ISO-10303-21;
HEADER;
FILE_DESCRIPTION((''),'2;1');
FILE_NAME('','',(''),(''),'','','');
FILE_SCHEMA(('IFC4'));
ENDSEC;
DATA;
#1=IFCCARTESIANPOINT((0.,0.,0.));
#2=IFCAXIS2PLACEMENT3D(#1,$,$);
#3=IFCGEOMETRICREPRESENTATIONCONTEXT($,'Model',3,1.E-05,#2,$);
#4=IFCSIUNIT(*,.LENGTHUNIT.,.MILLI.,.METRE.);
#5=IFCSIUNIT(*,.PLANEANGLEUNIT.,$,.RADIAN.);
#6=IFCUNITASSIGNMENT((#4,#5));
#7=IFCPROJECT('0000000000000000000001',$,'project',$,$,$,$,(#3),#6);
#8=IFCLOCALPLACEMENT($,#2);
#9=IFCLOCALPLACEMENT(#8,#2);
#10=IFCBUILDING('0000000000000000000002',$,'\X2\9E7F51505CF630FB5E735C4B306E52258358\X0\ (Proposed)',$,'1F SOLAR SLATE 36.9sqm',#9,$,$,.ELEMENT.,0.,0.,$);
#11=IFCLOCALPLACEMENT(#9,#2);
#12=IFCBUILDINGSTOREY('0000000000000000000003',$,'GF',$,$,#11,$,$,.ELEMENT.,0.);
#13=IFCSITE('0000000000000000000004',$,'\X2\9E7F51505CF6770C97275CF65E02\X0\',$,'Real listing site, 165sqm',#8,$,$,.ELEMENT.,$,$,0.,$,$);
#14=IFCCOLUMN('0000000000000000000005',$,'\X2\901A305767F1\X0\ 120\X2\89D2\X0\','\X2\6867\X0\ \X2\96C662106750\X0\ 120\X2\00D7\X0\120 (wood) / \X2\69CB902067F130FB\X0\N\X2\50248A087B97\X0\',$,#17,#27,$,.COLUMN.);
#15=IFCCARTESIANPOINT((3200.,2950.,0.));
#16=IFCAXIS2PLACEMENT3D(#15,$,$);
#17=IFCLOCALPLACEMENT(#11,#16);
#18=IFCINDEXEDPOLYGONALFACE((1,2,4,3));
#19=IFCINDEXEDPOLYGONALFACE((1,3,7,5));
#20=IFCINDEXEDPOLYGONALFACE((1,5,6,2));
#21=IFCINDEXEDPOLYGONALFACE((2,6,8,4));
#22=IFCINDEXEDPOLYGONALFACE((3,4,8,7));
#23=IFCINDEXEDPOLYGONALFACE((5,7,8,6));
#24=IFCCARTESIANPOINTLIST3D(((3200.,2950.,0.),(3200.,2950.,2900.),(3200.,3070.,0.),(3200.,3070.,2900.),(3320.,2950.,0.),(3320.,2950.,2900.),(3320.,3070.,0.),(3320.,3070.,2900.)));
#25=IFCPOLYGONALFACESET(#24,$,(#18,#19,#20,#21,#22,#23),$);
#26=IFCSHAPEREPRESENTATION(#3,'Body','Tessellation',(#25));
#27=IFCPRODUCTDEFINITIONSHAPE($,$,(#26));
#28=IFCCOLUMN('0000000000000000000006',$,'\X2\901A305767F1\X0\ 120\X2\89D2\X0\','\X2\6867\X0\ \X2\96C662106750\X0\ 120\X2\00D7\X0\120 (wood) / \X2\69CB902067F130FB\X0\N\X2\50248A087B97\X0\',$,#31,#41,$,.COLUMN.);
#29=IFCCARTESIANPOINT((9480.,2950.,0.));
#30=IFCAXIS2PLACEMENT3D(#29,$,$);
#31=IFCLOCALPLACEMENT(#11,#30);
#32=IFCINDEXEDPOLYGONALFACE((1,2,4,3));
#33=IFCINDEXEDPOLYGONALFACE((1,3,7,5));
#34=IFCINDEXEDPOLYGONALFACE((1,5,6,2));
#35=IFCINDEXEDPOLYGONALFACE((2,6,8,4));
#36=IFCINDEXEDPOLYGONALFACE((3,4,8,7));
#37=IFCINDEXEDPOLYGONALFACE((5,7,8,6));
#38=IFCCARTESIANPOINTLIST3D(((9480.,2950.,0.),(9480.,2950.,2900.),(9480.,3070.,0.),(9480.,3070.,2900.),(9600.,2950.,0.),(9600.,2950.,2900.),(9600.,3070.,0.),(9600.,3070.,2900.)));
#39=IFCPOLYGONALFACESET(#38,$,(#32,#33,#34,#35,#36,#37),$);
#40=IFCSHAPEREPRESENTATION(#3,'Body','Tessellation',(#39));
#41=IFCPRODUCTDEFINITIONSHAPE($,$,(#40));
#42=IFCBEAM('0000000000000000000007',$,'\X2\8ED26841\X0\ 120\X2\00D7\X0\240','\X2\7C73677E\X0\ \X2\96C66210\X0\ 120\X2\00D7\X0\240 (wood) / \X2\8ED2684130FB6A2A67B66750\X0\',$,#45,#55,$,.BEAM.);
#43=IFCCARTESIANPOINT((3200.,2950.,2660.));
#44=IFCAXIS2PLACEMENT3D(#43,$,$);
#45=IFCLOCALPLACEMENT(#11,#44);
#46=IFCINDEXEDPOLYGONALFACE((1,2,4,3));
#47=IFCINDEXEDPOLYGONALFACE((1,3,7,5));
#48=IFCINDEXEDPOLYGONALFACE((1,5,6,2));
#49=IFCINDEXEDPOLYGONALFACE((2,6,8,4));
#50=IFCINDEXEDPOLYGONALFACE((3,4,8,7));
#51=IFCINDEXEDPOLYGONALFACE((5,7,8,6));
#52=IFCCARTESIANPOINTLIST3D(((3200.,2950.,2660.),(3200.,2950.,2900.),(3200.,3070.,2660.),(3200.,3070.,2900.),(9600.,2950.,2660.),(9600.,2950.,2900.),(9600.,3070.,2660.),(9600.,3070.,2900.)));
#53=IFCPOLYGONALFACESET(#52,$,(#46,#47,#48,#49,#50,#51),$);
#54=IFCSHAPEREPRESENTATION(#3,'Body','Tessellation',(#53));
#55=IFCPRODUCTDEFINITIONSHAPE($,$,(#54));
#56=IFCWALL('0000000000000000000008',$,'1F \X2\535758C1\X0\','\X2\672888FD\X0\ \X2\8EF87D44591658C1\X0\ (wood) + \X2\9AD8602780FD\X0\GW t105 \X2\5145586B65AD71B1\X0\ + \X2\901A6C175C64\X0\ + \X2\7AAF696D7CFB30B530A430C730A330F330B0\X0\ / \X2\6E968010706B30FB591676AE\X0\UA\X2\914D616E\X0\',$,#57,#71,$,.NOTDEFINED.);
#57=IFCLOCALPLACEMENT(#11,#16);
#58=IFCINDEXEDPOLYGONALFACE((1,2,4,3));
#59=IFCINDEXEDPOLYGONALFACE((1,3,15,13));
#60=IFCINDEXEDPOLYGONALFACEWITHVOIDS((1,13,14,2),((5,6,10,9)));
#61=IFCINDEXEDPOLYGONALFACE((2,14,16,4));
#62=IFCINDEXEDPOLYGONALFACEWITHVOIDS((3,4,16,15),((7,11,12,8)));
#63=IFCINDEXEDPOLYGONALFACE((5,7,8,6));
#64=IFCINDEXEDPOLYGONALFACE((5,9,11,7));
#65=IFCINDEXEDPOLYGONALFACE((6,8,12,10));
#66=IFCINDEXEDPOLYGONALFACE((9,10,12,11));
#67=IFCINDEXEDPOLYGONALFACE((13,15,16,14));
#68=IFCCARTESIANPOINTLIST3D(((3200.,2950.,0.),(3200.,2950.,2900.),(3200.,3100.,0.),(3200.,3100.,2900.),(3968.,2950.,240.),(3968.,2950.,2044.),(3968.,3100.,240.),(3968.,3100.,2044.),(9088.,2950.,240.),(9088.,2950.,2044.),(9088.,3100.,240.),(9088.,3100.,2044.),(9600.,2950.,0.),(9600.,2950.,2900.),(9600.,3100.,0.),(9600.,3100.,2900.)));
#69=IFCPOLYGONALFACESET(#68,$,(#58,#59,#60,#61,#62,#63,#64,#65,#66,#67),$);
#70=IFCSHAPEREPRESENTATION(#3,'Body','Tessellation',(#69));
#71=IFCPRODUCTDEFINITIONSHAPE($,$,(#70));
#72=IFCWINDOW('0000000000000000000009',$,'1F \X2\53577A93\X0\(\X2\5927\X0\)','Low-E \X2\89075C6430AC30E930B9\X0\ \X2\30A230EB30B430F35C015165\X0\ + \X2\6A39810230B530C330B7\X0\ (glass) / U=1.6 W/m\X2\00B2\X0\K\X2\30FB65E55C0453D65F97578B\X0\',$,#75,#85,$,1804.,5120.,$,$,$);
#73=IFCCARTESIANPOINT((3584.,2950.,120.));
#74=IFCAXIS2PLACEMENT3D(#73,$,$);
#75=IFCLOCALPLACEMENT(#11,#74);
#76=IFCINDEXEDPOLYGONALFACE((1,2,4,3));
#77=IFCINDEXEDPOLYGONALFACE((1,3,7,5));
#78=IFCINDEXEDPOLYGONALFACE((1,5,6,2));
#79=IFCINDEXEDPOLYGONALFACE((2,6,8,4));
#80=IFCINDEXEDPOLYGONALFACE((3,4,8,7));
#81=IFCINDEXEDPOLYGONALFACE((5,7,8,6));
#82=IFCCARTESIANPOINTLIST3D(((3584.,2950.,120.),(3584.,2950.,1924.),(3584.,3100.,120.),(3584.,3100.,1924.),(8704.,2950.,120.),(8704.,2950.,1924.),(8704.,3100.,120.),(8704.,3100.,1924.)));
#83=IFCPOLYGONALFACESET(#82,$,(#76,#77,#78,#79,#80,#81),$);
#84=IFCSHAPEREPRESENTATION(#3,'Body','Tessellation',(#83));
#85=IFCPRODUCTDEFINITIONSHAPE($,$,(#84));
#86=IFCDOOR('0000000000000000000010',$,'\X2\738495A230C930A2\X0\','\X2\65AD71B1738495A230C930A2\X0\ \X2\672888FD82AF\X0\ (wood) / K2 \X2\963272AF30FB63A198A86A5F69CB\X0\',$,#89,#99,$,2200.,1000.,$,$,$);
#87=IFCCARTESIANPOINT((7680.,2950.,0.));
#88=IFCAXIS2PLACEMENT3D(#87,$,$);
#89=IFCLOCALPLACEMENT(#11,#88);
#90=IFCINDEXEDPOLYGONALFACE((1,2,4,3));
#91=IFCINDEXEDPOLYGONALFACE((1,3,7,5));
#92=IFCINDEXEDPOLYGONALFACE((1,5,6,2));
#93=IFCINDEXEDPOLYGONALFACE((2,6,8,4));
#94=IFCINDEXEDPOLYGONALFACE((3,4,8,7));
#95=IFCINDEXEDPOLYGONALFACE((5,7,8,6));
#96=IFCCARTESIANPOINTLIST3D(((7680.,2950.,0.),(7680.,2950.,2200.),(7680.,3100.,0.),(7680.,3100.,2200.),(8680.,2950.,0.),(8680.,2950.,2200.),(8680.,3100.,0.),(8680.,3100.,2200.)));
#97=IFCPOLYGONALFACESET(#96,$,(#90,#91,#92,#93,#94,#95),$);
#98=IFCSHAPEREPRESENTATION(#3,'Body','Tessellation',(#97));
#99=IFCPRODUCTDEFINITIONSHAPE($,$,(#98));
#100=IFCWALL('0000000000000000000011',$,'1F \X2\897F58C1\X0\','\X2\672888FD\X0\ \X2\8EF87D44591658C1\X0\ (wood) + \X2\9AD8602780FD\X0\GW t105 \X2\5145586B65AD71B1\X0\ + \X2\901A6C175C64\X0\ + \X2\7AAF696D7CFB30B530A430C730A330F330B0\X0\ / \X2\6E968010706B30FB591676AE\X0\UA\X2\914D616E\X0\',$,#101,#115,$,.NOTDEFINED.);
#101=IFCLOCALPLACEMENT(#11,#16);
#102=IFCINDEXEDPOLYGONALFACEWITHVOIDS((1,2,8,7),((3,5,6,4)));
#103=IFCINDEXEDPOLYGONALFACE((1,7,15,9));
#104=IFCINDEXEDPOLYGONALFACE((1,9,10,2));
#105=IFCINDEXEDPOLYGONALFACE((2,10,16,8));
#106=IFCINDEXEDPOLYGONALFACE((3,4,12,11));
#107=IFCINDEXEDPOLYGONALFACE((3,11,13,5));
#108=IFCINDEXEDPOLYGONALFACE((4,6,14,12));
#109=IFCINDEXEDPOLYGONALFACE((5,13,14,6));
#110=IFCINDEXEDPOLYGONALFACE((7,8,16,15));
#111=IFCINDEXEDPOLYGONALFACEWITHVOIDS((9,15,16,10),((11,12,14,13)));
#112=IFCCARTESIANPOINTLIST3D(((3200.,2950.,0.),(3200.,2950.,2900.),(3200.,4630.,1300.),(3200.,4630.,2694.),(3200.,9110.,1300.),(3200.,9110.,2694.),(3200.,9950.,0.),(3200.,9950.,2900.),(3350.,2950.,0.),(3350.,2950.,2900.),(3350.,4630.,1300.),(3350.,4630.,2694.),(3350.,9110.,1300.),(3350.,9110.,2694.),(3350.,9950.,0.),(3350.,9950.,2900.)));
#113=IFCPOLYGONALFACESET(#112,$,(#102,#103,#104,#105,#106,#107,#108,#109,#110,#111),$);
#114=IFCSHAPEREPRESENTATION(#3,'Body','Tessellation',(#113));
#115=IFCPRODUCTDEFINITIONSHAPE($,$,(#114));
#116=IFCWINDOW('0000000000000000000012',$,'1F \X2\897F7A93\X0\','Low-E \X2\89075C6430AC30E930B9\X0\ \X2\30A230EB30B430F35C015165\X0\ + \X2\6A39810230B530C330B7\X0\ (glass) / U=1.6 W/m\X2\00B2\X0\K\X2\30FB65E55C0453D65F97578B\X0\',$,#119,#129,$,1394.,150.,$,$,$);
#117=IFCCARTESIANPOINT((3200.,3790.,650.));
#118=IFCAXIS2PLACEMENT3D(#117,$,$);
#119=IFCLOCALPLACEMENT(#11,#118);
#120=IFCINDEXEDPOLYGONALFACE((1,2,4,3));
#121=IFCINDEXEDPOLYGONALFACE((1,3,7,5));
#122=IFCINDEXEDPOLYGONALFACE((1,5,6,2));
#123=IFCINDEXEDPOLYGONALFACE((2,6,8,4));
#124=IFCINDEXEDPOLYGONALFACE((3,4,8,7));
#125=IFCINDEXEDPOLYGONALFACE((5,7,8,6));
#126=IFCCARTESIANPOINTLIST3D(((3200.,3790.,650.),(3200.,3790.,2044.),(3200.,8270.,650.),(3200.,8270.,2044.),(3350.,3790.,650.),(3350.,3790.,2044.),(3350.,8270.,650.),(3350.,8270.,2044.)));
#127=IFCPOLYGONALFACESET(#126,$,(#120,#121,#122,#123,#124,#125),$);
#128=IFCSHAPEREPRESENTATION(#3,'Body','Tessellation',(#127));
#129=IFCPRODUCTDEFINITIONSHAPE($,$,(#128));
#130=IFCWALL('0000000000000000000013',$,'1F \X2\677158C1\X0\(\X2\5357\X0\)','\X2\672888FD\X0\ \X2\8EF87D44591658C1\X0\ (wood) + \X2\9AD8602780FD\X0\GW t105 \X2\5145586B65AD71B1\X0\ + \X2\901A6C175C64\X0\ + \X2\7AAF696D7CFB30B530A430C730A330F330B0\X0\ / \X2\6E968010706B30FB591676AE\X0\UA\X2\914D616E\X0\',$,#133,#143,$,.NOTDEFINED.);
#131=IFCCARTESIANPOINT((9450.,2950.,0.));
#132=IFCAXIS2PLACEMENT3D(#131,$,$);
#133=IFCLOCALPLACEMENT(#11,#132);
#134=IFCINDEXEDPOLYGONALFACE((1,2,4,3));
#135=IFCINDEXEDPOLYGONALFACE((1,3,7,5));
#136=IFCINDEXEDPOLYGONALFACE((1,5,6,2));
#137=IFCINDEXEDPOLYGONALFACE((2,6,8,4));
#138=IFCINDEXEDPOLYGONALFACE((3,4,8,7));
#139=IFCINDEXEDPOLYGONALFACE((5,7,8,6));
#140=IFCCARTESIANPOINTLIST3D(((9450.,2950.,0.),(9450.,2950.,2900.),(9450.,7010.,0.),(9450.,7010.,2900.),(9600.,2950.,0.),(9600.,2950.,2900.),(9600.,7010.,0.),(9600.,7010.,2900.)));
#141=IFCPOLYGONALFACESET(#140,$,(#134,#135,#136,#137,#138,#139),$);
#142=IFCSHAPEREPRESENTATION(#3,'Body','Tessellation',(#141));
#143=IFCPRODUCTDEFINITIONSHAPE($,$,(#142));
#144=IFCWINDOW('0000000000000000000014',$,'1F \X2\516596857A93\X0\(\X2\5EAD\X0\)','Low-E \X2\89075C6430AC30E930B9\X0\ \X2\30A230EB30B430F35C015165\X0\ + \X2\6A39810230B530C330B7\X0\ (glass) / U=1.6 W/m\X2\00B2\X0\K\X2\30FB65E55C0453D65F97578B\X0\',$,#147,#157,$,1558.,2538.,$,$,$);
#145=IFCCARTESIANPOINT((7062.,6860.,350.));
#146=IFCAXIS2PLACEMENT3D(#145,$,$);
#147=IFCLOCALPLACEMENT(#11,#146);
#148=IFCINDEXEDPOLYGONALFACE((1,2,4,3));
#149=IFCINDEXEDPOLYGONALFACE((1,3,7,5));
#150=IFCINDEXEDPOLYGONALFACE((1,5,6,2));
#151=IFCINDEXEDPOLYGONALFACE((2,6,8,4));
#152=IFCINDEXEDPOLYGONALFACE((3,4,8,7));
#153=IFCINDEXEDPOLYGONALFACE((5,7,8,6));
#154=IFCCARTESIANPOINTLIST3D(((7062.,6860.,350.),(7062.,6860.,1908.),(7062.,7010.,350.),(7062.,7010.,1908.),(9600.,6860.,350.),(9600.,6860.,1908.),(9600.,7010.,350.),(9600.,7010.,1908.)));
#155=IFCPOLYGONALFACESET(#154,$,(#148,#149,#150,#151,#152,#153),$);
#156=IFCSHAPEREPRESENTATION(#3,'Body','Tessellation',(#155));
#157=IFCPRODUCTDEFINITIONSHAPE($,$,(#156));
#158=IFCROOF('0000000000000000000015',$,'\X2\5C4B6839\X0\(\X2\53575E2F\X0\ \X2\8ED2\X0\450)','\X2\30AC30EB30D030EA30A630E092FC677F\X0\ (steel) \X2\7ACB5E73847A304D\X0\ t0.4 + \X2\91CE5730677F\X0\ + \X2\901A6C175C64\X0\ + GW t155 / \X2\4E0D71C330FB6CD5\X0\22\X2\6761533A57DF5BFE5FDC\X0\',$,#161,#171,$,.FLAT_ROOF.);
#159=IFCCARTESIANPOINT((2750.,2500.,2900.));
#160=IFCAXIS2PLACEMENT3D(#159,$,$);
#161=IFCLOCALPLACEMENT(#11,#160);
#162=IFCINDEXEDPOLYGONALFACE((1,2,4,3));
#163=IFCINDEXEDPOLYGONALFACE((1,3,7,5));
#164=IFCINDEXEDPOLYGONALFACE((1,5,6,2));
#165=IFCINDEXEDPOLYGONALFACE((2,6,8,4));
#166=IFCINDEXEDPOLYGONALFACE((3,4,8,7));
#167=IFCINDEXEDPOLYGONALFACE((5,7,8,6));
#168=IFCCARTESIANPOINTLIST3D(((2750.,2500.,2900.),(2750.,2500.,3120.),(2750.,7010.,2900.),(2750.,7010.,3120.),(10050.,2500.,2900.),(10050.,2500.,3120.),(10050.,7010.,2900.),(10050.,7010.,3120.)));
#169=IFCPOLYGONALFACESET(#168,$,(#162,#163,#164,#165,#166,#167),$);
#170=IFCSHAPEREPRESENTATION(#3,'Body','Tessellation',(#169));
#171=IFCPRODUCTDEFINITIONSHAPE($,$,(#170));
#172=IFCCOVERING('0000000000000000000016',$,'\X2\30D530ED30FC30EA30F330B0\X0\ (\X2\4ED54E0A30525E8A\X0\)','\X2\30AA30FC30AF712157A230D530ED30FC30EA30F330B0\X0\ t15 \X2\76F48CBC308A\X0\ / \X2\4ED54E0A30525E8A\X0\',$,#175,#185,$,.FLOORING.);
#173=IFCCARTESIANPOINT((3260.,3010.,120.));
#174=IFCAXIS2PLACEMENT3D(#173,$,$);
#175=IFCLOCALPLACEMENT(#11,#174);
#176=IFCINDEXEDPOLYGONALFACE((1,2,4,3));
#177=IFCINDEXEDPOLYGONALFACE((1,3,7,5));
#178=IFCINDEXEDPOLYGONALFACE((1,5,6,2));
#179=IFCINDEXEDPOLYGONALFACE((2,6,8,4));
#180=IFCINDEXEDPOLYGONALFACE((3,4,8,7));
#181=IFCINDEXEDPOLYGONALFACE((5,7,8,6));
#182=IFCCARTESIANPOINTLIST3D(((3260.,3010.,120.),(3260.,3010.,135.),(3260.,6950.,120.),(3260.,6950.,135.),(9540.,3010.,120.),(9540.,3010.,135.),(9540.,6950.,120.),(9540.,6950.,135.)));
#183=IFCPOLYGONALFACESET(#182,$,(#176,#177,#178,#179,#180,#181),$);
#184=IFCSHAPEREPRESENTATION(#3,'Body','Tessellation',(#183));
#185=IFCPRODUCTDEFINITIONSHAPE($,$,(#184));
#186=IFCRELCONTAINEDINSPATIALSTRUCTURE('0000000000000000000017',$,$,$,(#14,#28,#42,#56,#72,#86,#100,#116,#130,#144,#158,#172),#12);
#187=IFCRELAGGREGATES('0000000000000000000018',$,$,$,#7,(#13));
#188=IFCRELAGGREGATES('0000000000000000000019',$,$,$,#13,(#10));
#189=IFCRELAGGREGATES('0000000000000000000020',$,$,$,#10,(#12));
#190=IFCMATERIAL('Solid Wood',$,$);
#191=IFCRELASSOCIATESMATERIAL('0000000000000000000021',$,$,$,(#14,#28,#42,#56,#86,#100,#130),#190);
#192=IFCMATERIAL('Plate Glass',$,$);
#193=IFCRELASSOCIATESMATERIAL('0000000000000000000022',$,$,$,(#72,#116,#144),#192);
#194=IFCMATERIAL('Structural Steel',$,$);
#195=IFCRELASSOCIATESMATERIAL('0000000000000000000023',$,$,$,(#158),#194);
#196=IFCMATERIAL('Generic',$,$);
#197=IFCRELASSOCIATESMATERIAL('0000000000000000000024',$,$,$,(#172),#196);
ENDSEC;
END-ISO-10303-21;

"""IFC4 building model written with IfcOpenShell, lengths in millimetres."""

from ifc_helpers import new_model, si_unit, frame, frame_2d, origin, place, context, project, spatial, rectangle, extrude, material, element, fill, save


model = new_model("IFC4")

# Units and contexts
model_context = context("Model", 3, precision=1e-05, world=origin())
ifc_project = project(units=[si_unit("LENGTHUNIT", "METRE", prefix="MILLI"), si_unit("PLANEANGLEUNIT", "RADIAN")], contexts=[model_context])

# Site, building, storey
site_placement = place(None, origin())
site = spatial("IfcSite", under=ifc_project, at=site_placement, Name="鹿児島県霧島市", ObjectType="Real listing site, 165sqm", CompositionType="ELEMENT", RefElevation=0.0)
building_placement = place(site_placement, origin())
building = spatial("IfcBuilding", under=site, at=building_placement, Name="鹿児島・平屋の別荘 (Proposed)", ObjectType="1F SOLAR SLATE 36.9sqm", CompositionType="ELEMENT", ElevationOfRefHeight=0.0, ElevationOfTerrain=0.0)
storey_placement = place(building_placement, origin())
storey = spatial("IfcBuildingStorey", under=building, at=storey_placement, Name="GF", CompositionType="ELEMENT", Elevation=0.0)

# Columns
ifc_material_1 = material(Name="Solid Wood")
column_1_placement = place(storey_placement, frame((3200.0, 2950.0, 0.0)))
element("IfcColumn", 1, at=column_1_placement, inside=storey, material=ifc_material_1, Name="通し柱 120角", Description="桧 集成材 120×120 (wood) / 構造柱・N値計算", PredefinedType="COLUMN", context=model_context, shape_type="SweptSolid", body=[
    extrude(rectangle(XDim=120.0, YDim=120.0, at=frame_2d((60.0, 60.0))), frame((3200.0, 2950.0, 0.0)), (0.0, 0.0, 1.0), 2900.0),
])
column_2_placement = place(storey_placement, frame((9480.0, 2950.0, 0.0)))
element("IfcColumn", 2, at=column_2_placement, inside=storey, material=ifc_material_1, Name="通し柱 120角", Description="桧 集成材 120×120 (wood) / 構造柱・N値計算", PredefinedType="COLUMN", context=model_context, shape_type="SweptSolid", body=[
    extrude(rectangle(XDim=120.0, YDim=120.0, at=frame_2d((60.0, 60.0))), frame((9480.0, 2950.0, 0.0)), (0.0, 0.0, 1.0), 2900.0),
])

# Beam
beam_1_placement = place(storey_placement, frame((3200.0, 2950.0, 2660.0)))
element("IfcBeam", 3, at=beam_1_placement, inside=storey, material=ifc_material_1, Name="軒桁 120×240", Description="米松 集成 120×240 (wood) / 軒桁・横架材", PredefinedType="BEAM", context=model_context, shape_type="SweptSolid", body=[
    extrude(rectangle(XDim=6400.0, YDim=120.0, at=frame_2d((3200.0, 60.0))), frame((3200.0, 2950.0, 2660.0)), (0.0, 0.0, 1.0), 240.0),
])

# Wall, openings, window, door
wall_1_placement = place(storey_placement, frame((3200.0, 2950.0, 0.0)))
wall_1 = element("IfcWall", 4, at=wall_1_placement, inside=storey, material=ifc_material_1, Name="1F 南壁", Description="木製 軸組外壁 (wood) + 高性能GW t105 充填断熱 + 通気層 + 窯業系サイディング / 準耐火・外皮UA配慮", PredefinedType="NOTDEFINED", context=model_context, shape_type="SweptSolid", body=[
    extrude(rectangle(XDim=6400.0, YDim=150.0, at=frame_2d((3200.0, 75.0))), frame((3200.0, 2950.0, 0.0)), (0.0, 0.0, 1.0), 2900.0),
])
opening_1_placement = place(storey_placement, frame((3584.0, 2950.0, 120.0)))
opening_1 = element("IfcOpeningElement", 5, at=opening_1_placement, cuts=wall_1, PredefinedType="NOTDEFINED", context=model_context, shape_type="SweptSolid", body=[
    extrude(rectangle(XDim=5120.0, YDim=150.0, at=frame_2d((2560.0, 75.0))), frame((3584.0, 2950.0, 120.0)), (0.0, 0.0, 1.0), 1804.0),
])
opening_2_placement = place(storey_placement, frame((7680.0, 2950.0, 0.0)))
opening_2 = element("IfcOpeningElement", 6, at=opening_2_placement, cuts=wall_1, PredefinedType="NOTDEFINED", context=model_context, shape_type="SweptSolid", body=[
    extrude(rectangle(XDim=1000.0, YDim=150.0, at=frame_2d((500.0, 75.0))), frame((7680.0, 2950.0, 0.0)), (0.0, 0.0, 1.0), 2200.0),
])
ifc_material_2 = material(Name="Plate Glass")
window_1_placement = place(storey_placement, frame((3584.0, 2950.0, 120.0)))
window_1 = element("IfcWindow", 7, at=window_1_placement, inside=storey, material=ifc_material_2, Name="1F 南窓(大)", Description="Low-E 複層ガラス アルゴン封入 + 樹脂サッシ (glass) / U=1.6 W/m²K・日射取得型", OverallHeight=1804.0, OverallWidth=5120.0, context=model_context, shape_type="SweptSolid", body=[
    extrude(rectangle(XDim=5120.0, YDim=150.0, at=frame_2d((2560.0, 75.0))), frame((3584.0, 2950.0, 120.0)), (0.0, 0.0, 1.0), 1804.0),
])
fill(opening_1, window_1)
door_1_placement = place(storey_placement, frame((7680.0, 2950.0, 0.0)))
door_1 = element("IfcDoor", 8, at=door_1_placement, inside=storey, material=ifc_material_1, Name="玄関ドア", Description="断熱玄関ドア 木製芯 (wood) / K2 防犯・採風機構", OverallHeight=2200.0, OverallWidth=1000.0, context=model_context, shape_type="SweptSolid", body=[
    extrude(rectangle(XDim=1000.0, YDim=150.0, at=frame_2d((500.0, 75.0))), frame((7680.0, 2950.0, 0.0)), (0.0, 0.0, 1.0), 2200.0),
])
fill(opening_2, door_1)

# Walls, openings, windows
wall_2_placement = place(storey_placement, frame((3200.0, 2950.0, 0.0)))
wall_2 = element("IfcWall", 9, at=wall_2_placement, inside=storey, material=ifc_material_1, Name="1F 西壁", Description="木製 軸組外壁 (wood) + 高性能GW t105 充填断熱 + 通気層 + 窯業系サイディング / 準耐火・外皮UA配慮", PredefinedType="NOTDEFINED", context=model_context, shape_type="SweptSolid", body=[
    extrude(rectangle(XDim=150.0, YDim=7000.0, at=frame_2d((75.0, 3500.0))), frame((3200.0, 2950.0, 0.0)), (0.0, 0.0, 1.0), 2900.0),
])
opening_3_placement = place(storey_placement, frame((3200.0, 3790.0, 650.0)))
opening_3 = element("IfcOpeningElement", 10, at=opening_3_placement, cuts=wall_2, PredefinedType="NOTDEFINED", context=model_context, shape_type="SweptSolid", body=[
    extrude(rectangle(XDim=150.0, YDim=4480.0, at=frame_2d((75.0, 2240.0))), frame((3200.0, 3790.0, 650.0)), (0.0, 0.0, 1.0), 1394.0),
])
window_2_placement = place(storey_placement, frame((3200.0, 3790.0, 650.0)))
window_2 = element("IfcWindow", 11, at=window_2_placement, inside=storey, material=ifc_material_2, Name="1F 西窓", Description="Low-E 複層ガラス アルゴン封入 + 樹脂サッシ (glass) / U=1.6 W/m²K・日射取得型", OverallHeight=1394.0, OverallWidth=150.0, context=model_context, shape_type="SweptSolid", body=[
    extrude(rectangle(XDim=150.0, YDim=4480.0, at=frame_2d((75.0, 2240.0))), frame((3200.0, 3790.0, 650.0)), (0.0, 0.0, 1.0), 1394.0),
])
fill(opening_3, window_2)
wall_3_placement = place(storey_placement, frame((9450.0, 2950.0, 0.0)))
wall_3 = element("IfcWall", 12, at=wall_3_placement, inside=storey, material=ifc_material_1, Name="1F 東壁(南)", Description="木製 軸組外壁 (wood) + 高性能GW t105 充填断熱 + 通気層 + 窯業系サイディング / 準耐火・外皮UA配慮", PredefinedType="NOTDEFINED", context=model_context, shape_type="SweptSolid", body=[
    extrude(rectangle(XDim=150.0, YDim=4060.0, at=frame_2d((75.0, 2030.0))), frame((9450.0, 2950.0, 0.0)), (0.0, 0.0, 1.0), 2900.0),
])
opening_4_placement = place(storey_placement, frame((7062.0, 6860.0, 350.0)))
opening_4 = element("IfcOpeningElement", 13, at=opening_4_placement, cuts=wall_3, PredefinedType="NOTDEFINED", context=model_context, shape_type="SweptSolid", body=[
    extrude(rectangle(XDim=2538.0, YDim=150.0, at=frame_2d((1269.0, 75.0))), frame((7062.0, 6860.0, 350.0)), (0.0, 0.0, 1.0), 1558.0),
])
window_3_placement = place(storey_placement, frame((7062.0, 6860.0, 350.0)))
window_3 = element("IfcWindow", 14, at=window_3_placement, inside=storey, material=ifc_material_2, Name="1F 入隅窓(庭)", Description="Low-E 複層ガラス アルゴン封入 + 樹脂サッシ (glass) / U=1.6 W/m²K・日射取得型", OverallHeight=1558.0, OverallWidth=2538.0, context=model_context, shape_type="SweptSolid", body=[
    extrude(rectangle(XDim=2538.0, YDim=150.0, at=frame_2d((1269.0, 75.0))), frame((7062.0, 6860.0, 350.0)), (0.0, 0.0, 1.0), 1558.0),
])
fill(opening_4, window_3)

# Roof
ifc_material_3 = material(Name="Structural Steel")
roof_placement = place(storey_placement, frame((2750.0, 2500.0, 2900.0)))
element("IfcRoof", 15, at=roof_placement, inside=storey, material=ifc_material_3, Name="屋根(南帯 軒450)", Description="ガルバリウム鋼板 (steel) 立平葺き t0.4 + 野地板 + 通気層 + GW t155 / 不燃・法22条区域対応", PredefinedType="FLAT_ROOF", context=model_context, shape_type="SweptSolid", body=[
    extrude(rectangle(XDim=7300.0, YDim=4510.0, at=frame_2d((3650.0, 2255.0))), frame((2750.0, 2500.0, 2900.0)), (0.0, 0.0, 1.0), 220.0),
])

# Covering
ifc_material_4 = material(Name="Generic")
covering_1_placement = place(storey_placement, frame((3260.0, 3010.0, 120.0)))
element("IfcCovering", 16, at=covering_1_placement, inside=storey, material=ifc_material_4, Name="フローリング (仕上げ床)", Description="オーク無垢フローリング t15 直貼り / 仕上げ床", PredefinedType="FLOORING", context=model_context, shape_type="SweptSolid", body=[
    extrude(rectangle(XDim=6280.0, YDim=3940.0, at=frame_2d((3140.0, 1970.0))), frame((3260.0, 3010.0, 120.0)), (0.0, 0.0, 1.0), 15.0),
])

save(model, "model.ifc")
